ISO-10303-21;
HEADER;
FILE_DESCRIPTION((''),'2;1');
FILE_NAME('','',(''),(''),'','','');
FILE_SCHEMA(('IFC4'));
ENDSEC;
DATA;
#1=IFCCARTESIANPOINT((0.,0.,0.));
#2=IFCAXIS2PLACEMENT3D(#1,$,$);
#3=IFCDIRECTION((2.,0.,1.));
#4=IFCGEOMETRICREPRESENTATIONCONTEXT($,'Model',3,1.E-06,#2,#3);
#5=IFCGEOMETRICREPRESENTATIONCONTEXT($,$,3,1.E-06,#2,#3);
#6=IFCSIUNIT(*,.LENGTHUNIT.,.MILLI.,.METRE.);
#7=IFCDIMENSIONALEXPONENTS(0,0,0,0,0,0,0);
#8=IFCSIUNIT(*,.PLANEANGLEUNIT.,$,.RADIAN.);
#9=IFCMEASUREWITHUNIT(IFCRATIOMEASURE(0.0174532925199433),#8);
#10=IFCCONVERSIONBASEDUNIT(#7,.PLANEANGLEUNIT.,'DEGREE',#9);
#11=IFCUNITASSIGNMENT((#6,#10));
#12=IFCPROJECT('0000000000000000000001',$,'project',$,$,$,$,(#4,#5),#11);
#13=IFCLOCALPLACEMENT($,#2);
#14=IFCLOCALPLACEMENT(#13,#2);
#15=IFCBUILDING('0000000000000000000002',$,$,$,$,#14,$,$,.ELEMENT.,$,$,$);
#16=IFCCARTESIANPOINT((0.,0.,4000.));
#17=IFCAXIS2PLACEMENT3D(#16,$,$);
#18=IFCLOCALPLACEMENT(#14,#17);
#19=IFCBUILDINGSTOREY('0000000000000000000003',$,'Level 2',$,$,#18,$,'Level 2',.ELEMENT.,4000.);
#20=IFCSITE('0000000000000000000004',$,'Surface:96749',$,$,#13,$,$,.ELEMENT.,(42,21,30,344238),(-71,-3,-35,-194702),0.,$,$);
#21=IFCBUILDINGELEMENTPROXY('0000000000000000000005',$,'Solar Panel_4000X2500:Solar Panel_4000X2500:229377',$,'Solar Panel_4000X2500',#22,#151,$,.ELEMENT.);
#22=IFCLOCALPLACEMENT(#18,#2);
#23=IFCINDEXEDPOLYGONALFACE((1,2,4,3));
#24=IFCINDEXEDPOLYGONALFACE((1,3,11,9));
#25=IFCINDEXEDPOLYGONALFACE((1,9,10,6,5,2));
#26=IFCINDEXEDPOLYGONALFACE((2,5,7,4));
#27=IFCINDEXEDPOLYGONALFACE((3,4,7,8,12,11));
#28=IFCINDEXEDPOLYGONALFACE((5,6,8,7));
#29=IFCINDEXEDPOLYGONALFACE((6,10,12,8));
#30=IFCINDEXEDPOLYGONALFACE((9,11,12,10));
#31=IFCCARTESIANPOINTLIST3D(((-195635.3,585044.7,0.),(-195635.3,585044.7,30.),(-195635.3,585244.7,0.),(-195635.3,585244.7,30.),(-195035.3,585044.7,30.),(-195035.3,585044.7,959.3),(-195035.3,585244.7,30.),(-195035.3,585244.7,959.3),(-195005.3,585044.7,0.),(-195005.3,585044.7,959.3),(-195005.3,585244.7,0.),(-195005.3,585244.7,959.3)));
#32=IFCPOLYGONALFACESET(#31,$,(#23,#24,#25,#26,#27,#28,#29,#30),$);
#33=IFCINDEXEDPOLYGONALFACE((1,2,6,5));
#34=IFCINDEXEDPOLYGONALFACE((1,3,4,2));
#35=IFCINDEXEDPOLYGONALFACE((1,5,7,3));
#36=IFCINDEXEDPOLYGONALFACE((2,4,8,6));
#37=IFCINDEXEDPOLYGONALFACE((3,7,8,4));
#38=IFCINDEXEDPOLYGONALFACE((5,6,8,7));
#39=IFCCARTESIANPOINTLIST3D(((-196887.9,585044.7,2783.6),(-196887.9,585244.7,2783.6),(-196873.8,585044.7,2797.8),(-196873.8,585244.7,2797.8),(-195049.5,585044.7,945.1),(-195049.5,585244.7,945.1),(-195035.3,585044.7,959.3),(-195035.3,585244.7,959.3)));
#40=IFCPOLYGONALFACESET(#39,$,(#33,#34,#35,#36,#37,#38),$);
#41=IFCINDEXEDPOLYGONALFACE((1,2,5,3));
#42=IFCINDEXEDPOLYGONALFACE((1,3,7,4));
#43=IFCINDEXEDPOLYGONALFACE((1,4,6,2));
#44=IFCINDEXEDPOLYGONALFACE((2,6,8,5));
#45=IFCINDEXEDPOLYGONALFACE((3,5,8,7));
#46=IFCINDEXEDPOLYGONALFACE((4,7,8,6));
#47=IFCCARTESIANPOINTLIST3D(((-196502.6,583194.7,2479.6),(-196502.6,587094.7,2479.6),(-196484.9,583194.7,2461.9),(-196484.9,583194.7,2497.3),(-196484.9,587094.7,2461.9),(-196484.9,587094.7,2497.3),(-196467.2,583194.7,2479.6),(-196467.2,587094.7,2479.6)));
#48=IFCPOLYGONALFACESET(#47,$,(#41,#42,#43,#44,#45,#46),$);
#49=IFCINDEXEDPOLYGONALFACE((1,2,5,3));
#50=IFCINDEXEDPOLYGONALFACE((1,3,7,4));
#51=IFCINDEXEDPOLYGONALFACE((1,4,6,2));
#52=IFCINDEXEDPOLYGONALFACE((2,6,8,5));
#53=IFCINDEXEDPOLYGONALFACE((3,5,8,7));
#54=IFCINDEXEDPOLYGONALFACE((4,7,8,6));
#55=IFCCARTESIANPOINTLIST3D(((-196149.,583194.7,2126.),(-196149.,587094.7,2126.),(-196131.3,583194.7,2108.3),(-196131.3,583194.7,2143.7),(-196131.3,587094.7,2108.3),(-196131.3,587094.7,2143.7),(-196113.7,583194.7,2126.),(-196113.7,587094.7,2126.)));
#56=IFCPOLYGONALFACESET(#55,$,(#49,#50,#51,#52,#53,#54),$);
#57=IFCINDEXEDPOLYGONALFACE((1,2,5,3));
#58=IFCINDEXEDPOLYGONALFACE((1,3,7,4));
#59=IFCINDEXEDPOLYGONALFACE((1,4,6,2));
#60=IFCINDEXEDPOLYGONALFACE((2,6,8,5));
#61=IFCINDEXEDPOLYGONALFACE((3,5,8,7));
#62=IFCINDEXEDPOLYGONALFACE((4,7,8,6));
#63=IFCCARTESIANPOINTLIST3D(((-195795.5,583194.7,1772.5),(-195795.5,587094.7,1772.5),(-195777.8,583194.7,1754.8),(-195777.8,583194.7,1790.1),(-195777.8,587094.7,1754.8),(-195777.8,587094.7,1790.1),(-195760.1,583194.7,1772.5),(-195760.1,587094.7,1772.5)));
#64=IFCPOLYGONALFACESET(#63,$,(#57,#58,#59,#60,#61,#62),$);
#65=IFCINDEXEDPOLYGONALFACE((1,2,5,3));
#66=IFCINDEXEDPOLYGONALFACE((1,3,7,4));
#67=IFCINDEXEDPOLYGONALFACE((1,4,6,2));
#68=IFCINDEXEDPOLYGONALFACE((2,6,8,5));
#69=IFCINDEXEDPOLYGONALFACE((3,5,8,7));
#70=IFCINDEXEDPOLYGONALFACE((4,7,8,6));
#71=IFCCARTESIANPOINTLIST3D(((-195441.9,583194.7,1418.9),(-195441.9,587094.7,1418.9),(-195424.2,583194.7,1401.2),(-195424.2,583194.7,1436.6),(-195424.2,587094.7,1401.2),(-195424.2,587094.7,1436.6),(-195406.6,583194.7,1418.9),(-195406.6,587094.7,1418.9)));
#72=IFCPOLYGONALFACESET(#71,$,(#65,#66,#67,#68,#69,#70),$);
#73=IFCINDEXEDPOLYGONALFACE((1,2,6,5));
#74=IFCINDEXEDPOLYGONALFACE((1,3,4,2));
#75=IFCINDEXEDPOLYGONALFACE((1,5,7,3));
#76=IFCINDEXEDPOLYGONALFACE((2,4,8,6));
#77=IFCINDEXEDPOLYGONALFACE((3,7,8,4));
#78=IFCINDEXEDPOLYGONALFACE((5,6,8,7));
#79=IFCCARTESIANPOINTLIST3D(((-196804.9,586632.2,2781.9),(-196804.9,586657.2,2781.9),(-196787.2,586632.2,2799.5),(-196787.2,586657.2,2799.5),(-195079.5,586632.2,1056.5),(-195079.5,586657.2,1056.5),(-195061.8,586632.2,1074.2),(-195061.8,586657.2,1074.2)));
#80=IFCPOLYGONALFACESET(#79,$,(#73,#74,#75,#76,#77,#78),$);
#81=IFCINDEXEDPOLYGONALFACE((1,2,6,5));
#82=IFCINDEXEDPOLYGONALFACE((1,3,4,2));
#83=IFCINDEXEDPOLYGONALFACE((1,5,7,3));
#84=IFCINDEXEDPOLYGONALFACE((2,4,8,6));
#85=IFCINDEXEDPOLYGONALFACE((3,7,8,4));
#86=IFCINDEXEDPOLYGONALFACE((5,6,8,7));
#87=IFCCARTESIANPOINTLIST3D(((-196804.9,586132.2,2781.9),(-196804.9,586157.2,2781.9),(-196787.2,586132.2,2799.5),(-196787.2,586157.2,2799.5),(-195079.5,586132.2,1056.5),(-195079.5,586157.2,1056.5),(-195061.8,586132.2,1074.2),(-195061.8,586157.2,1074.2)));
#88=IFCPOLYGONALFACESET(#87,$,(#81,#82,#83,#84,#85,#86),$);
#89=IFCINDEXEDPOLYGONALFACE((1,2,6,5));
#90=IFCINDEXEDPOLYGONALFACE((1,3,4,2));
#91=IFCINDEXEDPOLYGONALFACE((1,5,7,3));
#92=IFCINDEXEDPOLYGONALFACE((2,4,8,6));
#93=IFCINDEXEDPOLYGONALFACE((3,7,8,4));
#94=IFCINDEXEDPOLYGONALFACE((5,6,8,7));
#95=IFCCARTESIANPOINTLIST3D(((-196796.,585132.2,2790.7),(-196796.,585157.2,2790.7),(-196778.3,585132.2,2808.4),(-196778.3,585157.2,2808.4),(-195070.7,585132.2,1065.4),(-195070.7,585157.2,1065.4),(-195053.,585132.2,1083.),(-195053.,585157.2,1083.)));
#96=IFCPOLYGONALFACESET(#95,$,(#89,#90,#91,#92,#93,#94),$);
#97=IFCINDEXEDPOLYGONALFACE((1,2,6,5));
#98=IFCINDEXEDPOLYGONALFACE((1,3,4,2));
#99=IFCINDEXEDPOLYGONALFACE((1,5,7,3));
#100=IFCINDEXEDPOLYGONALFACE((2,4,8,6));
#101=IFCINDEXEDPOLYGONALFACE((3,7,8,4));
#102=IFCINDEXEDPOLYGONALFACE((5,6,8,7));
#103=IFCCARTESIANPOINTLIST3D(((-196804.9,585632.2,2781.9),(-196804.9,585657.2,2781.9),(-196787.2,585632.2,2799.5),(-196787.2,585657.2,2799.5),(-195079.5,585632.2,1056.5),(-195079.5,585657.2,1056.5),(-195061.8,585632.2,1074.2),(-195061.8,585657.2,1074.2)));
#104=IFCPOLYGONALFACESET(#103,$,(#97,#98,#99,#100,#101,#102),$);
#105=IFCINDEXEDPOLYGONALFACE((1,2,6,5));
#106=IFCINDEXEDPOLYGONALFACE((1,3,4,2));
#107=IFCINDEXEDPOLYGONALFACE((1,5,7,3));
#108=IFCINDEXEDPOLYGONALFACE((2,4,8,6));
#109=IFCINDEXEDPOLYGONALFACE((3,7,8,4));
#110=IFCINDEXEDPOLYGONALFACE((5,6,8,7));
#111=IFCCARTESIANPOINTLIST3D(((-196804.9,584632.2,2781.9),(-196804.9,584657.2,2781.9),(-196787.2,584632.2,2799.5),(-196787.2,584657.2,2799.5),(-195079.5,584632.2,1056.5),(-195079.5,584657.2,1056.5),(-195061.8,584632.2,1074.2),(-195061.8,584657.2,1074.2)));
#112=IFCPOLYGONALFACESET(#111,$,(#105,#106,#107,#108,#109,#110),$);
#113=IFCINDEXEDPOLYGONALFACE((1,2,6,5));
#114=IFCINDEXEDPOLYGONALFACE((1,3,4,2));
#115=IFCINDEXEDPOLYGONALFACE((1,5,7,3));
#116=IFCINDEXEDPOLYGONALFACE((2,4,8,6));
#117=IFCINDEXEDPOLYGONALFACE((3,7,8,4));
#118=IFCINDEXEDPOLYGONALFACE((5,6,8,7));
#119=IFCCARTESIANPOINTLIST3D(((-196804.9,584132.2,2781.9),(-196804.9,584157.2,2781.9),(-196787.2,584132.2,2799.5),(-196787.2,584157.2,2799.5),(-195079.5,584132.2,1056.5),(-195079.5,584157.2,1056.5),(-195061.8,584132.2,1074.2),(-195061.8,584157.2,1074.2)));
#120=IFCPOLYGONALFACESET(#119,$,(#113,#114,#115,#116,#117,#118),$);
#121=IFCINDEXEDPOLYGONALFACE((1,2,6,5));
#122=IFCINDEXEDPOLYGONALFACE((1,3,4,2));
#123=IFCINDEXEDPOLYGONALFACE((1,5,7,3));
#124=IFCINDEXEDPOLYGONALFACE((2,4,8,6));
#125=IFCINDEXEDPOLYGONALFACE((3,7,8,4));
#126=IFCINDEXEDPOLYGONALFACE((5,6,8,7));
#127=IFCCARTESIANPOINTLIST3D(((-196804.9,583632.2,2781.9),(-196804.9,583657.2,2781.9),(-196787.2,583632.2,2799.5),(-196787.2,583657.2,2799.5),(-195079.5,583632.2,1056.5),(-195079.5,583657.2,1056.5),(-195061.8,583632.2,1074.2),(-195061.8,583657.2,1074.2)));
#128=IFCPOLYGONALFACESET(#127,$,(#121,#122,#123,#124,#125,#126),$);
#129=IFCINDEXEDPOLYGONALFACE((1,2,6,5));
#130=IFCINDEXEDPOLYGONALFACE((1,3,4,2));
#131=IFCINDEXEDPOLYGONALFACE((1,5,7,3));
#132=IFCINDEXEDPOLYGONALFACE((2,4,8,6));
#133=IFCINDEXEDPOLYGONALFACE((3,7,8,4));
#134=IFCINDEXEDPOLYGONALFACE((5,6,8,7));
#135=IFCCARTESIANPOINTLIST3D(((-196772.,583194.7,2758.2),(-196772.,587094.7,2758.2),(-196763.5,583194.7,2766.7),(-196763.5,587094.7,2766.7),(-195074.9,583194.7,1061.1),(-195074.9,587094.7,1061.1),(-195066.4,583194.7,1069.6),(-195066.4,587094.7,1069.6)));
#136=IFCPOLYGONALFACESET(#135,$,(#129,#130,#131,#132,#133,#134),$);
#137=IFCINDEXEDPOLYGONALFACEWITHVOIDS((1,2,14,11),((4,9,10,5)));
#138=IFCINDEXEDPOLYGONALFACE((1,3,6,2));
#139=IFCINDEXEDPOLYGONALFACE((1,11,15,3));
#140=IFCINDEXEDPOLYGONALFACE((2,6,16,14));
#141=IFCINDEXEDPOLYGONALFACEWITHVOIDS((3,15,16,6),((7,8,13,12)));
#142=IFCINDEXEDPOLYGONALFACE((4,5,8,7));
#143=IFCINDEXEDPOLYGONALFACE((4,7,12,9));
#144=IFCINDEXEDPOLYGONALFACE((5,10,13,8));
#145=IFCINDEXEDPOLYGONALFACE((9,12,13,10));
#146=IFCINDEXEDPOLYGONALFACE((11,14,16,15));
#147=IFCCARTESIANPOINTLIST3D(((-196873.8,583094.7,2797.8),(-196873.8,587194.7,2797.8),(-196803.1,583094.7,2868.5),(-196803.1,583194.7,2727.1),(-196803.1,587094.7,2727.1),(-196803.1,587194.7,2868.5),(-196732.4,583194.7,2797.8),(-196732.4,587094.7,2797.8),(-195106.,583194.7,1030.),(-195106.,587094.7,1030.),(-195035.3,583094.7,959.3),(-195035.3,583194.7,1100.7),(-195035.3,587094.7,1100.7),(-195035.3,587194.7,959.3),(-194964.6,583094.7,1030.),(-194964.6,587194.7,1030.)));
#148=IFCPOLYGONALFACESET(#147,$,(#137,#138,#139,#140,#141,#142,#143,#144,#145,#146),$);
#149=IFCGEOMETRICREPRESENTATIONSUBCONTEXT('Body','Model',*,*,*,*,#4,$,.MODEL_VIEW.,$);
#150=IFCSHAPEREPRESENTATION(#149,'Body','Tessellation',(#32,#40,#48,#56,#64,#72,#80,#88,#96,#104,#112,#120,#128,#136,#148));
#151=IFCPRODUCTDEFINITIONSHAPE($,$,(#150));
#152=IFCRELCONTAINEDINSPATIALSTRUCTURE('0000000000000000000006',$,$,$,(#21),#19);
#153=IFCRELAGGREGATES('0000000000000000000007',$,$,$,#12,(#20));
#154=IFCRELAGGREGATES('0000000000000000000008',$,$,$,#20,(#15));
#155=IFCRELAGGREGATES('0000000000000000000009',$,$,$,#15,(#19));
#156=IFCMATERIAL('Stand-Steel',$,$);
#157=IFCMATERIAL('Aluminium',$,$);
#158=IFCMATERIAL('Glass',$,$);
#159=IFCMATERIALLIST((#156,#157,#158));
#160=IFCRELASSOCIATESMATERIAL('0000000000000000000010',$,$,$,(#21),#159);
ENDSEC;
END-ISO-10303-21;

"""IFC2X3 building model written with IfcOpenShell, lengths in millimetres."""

from ifc_helpers import new_model, entity, si_unit, converted_unit, direction, frame, frame_2d, origin, origin_2d_with_axis, place, context, subcontext, project, spatial, polyline, rectangle, outline, extrude, source, transform, mapped, material, material_list, element, save


model = new_model("IFC2X3")

# Units and contexts
model_context = context("Model", 3, precision=1e-06, world=origin(), true_north=direction((2.0, 0.0, 1.0)))
context_of_model = context(None, 3, precision=1e-06, world=origin(), true_north=direction((2.0, 0.0, 1.0)))
body_context = subcontext(model_context, "Body", "Model", "MODEL_VIEW")
ifc_project = project(units=[si_unit("LENGTHUNIT", "METRE", prefix="MILLI"), converted_unit("PLANEANGLEUNIT", "DEGREE", entity("IfcRatioMeasure", 0.0174532925199433), si_unit("PLANEANGLEUNIT", "RADIAN"), dimensions=[0, 0, 0, 0, 0, 0, 0])], contexts=[model_context, context_of_model])

# Site, building, storey
site_placement = place(None, origin())
site = spatial("IfcSite", under=ifc_project, at=site_placement, Name="Surface:96749", CompositionType="ELEMENT", RefLatitude=(42, 21, 30, 344238), RefLongitude=(-71, -3, -35, -194702), RefElevation=0.0)
building_placement = place(site_placement, origin())
building = spatial("IfcBuilding", under=site, at=building_placement, CompositionType="ELEMENT")
storey_placement = place(building_placement, frame((0.0, 0.0, 4000.0)))
storey = spatial("IfcBuildingStorey", under=building, at=storey_placement, Name="Level 2", LongName="Level 2", CompositionType="ELEMENT", Elevation=4000.0)

# Building element proxy
ifc_material_1 = material(Name="Stand-Steel")
ifc_material_2 = material(Name="Aluminium")
ifc_material_3 = material(Name="Glass")
shared_shape = source(origin(), body_context, "Body", "SweptSolid", [
    extrude(outline(polyline([(-629.5, -220.0), (329.8, -220.0), (329.8, 410.0), (299.8, 410.0), (299.8, -190.0), (-629.5, -190.0), (-629.5, -220.0)])), frame((-190.0, -100.0, 299.8), z_axis=(0.0, 1.0, 0.0), x_axis=(0.0, 0.0, -1.0)), (0.0, 0.0, 1.0), 200.0),
    extrude(rectangle(XDim=20.0, YDim=200.0, at=frame_2d((0.0, 0.0), x_axis=(0.0, 1.0))), frame((-7.1, 0.0, 922.2), z_axis=(-0.707107, 0.0, 0.707107), x_axis=(0.0, 1.0, 0.0)), (0.0, 0.0, 1.0), 2600.0),
    extrude(rectangle(XDim=25.0, YDim=25.0, at=frame_2d((0.0, 0.0), x_axis=(1.0, 0.0))), frame((-1449.6, -1950.0, 2449.6), z_axis=(0.0, 1.0, 0.0), x_axis=(-0.707107, 0.0, -0.707107)), (0.0, 0.0, 1.0), 3900.0),
    extrude(rectangle(XDim=25.0, YDim=25.0, at=origin_2d_with_axis()), frame((-1096.0, -1950.0, 2096.0), z_axis=(0.0, 1.0, 0.0), x_axis=(-0.707107, 0.0, -0.707107)), (0.0, 0.0, 1.0), 3900.0),
    extrude(rectangle(XDim=25.0, YDim=25.0, at=origin_2d_with_axis()), frame((-742.5, -1950.0, 1742.5), z_axis=(0.0, 1.0, 0.0), x_axis=(-0.707107, 0.0, -0.707107)), (0.0, 0.0, 1.0), 3900.0),
    extrude(rectangle(XDim=25.0, YDim=25.0, at=frame_2d((0.0, 0.0), x_axis=(1.0, 0.0))), frame((-388.9, -1950.0, 1388.9), z_axis=(0.0, 1.0, 0.0), x_axis=(-0.707107, 0.0, -0.707107)), (0.0, 0.0, 1.0), 3900.0),
    extrude(rectangle(XDim=25.0, YDim=25.0, at=frame_2d((0.0, 0.0), x_axis=(0.0, 1.0))), frame((-35.4, 1500.0, 1035.4), z_axis=(-0.707107, 0.0, 0.707107), x_axis=(0.0, 1.0, 0.0)), (0.0, 0.0, 1.0), 2440.0),
    extrude(rectangle(XDim=25.0, YDim=25.0, at=frame_2d((0.0, 0.0), x_axis=(0.0, 1.0))), frame((-35.4, 1000.0, 1035.4), z_axis=(-0.707107, 0.0, 0.707107), x_axis=(0.0, 1.0, 0.0)), (0.0, 0.0, 1.0), 2440.0),
    extrude(rectangle(XDim=25.0, YDim=25.0, at=frame_2d((0.0, 0.0), x_axis=(0.0, 1.0))), frame((-26.5, 0.0, 1044.2), z_axis=(-0.707107, 0.0, 0.707107), x_axis=(0.0, -1.0, 0.0)), (0.0, 0.0, 1.0), 2440.0),
    extrude(rectangle(XDim=25.0, YDim=25.0, at=frame_2d((0.0, 0.0), x_axis=(0.0, 1.0))), frame((-35.4, 500.0, 1035.4), z_axis=(-0.707107, 0.0, 0.707107), x_axis=(0.0, 1.0, 0.0)), (0.0, 0.0, 1.0), 2440.0),
    extrude(rectangle(XDim=25.0, YDim=25.0, at=frame_2d((0.0, 0.0), x_axis=(0.0, 1.0))), frame((-35.4, -500.0, 1035.4), z_axis=(-0.707107, 0.0, 0.707107), x_axis=(0.0, 1.0, 0.0)), (0.0, 0.0, 1.0), 2440.0),
    extrude(rectangle(XDim=25.0, YDim=25.0, at=frame_2d((0.0, 0.0), x_axis=(0.0, 1.0))), frame((-35.4, -1000.0, 1035.4), z_axis=(-0.707107, 0.0, 0.707107), x_axis=(0.0, 1.0, 0.0)), (0.0, 0.0, 1.0), 2440.0),
    extrude(rectangle(XDim=25.0, YDim=25.0, at=frame_2d((0.0, 0.0), x_axis=(0.0, 1.0))), frame((-35.4, -1500.0, 1035.4), z_axis=(-0.707107, 0.0, 0.707107), x_axis=(0.0, 1.0, 0.0)), (0.0, 0.0, 1.0), 2440.0),
    extrude(rectangle(XDim=2400.0, YDim=12.0, at=frame_2d((0.0, 0.0), x_axis=(1.0, 0.0))), frame((-883.9, -1950.0, 1883.9), z_axis=(0.0, 1.0, 0.0), x_axis=(0.707107, 0.0, -0.707107)), (0.0, 0.0, 1.0), 3900.0),
    extrude(outline(polyline([(-2050.0, -1300.0), (2050.0, -1300.0), (2050.0, 1300.0), (-2050.0, 1300.0), (-2050.0, -1300.0)]), holes=[polyline([(1950.0, -1200.0), (-1950.0, -1200.0), (-1950.0, 1200.0), (1950.0, 1200.0), (1950.0, -1200.0)])]), frame((-919.2, 0.0, 1848.5), z_axis=(0.707107, 0.0, 0.707107), x_axis=(0.0, 1.0, 0.0)), (0.0, 0.0, 1.0), 100.0),
])
ifc_material_list_1 = material_list([ifc_material_1, ifc_material_2, ifc_material_3])
proxy_1_placement = place(storey_placement, frame((-195035.3, 585144.7, 30.0)))
element("IfcBuildingElementProxy", 1, at=proxy_1_placement, inside=storey, material=ifc_material_list_1, Name="Solar Panel_4000X2500:Solar Panel_4000X2500:229377", ObjectType="Solar Panel_4000X2500", CompositionType="ELEMENT", context=body_context, shape_type="MappedRepresentation", body=[
    mapped(shared_shape, transform((0.0, 0.0, 0.0), scale=1.0)),
])

save(model, "model.ifc")
